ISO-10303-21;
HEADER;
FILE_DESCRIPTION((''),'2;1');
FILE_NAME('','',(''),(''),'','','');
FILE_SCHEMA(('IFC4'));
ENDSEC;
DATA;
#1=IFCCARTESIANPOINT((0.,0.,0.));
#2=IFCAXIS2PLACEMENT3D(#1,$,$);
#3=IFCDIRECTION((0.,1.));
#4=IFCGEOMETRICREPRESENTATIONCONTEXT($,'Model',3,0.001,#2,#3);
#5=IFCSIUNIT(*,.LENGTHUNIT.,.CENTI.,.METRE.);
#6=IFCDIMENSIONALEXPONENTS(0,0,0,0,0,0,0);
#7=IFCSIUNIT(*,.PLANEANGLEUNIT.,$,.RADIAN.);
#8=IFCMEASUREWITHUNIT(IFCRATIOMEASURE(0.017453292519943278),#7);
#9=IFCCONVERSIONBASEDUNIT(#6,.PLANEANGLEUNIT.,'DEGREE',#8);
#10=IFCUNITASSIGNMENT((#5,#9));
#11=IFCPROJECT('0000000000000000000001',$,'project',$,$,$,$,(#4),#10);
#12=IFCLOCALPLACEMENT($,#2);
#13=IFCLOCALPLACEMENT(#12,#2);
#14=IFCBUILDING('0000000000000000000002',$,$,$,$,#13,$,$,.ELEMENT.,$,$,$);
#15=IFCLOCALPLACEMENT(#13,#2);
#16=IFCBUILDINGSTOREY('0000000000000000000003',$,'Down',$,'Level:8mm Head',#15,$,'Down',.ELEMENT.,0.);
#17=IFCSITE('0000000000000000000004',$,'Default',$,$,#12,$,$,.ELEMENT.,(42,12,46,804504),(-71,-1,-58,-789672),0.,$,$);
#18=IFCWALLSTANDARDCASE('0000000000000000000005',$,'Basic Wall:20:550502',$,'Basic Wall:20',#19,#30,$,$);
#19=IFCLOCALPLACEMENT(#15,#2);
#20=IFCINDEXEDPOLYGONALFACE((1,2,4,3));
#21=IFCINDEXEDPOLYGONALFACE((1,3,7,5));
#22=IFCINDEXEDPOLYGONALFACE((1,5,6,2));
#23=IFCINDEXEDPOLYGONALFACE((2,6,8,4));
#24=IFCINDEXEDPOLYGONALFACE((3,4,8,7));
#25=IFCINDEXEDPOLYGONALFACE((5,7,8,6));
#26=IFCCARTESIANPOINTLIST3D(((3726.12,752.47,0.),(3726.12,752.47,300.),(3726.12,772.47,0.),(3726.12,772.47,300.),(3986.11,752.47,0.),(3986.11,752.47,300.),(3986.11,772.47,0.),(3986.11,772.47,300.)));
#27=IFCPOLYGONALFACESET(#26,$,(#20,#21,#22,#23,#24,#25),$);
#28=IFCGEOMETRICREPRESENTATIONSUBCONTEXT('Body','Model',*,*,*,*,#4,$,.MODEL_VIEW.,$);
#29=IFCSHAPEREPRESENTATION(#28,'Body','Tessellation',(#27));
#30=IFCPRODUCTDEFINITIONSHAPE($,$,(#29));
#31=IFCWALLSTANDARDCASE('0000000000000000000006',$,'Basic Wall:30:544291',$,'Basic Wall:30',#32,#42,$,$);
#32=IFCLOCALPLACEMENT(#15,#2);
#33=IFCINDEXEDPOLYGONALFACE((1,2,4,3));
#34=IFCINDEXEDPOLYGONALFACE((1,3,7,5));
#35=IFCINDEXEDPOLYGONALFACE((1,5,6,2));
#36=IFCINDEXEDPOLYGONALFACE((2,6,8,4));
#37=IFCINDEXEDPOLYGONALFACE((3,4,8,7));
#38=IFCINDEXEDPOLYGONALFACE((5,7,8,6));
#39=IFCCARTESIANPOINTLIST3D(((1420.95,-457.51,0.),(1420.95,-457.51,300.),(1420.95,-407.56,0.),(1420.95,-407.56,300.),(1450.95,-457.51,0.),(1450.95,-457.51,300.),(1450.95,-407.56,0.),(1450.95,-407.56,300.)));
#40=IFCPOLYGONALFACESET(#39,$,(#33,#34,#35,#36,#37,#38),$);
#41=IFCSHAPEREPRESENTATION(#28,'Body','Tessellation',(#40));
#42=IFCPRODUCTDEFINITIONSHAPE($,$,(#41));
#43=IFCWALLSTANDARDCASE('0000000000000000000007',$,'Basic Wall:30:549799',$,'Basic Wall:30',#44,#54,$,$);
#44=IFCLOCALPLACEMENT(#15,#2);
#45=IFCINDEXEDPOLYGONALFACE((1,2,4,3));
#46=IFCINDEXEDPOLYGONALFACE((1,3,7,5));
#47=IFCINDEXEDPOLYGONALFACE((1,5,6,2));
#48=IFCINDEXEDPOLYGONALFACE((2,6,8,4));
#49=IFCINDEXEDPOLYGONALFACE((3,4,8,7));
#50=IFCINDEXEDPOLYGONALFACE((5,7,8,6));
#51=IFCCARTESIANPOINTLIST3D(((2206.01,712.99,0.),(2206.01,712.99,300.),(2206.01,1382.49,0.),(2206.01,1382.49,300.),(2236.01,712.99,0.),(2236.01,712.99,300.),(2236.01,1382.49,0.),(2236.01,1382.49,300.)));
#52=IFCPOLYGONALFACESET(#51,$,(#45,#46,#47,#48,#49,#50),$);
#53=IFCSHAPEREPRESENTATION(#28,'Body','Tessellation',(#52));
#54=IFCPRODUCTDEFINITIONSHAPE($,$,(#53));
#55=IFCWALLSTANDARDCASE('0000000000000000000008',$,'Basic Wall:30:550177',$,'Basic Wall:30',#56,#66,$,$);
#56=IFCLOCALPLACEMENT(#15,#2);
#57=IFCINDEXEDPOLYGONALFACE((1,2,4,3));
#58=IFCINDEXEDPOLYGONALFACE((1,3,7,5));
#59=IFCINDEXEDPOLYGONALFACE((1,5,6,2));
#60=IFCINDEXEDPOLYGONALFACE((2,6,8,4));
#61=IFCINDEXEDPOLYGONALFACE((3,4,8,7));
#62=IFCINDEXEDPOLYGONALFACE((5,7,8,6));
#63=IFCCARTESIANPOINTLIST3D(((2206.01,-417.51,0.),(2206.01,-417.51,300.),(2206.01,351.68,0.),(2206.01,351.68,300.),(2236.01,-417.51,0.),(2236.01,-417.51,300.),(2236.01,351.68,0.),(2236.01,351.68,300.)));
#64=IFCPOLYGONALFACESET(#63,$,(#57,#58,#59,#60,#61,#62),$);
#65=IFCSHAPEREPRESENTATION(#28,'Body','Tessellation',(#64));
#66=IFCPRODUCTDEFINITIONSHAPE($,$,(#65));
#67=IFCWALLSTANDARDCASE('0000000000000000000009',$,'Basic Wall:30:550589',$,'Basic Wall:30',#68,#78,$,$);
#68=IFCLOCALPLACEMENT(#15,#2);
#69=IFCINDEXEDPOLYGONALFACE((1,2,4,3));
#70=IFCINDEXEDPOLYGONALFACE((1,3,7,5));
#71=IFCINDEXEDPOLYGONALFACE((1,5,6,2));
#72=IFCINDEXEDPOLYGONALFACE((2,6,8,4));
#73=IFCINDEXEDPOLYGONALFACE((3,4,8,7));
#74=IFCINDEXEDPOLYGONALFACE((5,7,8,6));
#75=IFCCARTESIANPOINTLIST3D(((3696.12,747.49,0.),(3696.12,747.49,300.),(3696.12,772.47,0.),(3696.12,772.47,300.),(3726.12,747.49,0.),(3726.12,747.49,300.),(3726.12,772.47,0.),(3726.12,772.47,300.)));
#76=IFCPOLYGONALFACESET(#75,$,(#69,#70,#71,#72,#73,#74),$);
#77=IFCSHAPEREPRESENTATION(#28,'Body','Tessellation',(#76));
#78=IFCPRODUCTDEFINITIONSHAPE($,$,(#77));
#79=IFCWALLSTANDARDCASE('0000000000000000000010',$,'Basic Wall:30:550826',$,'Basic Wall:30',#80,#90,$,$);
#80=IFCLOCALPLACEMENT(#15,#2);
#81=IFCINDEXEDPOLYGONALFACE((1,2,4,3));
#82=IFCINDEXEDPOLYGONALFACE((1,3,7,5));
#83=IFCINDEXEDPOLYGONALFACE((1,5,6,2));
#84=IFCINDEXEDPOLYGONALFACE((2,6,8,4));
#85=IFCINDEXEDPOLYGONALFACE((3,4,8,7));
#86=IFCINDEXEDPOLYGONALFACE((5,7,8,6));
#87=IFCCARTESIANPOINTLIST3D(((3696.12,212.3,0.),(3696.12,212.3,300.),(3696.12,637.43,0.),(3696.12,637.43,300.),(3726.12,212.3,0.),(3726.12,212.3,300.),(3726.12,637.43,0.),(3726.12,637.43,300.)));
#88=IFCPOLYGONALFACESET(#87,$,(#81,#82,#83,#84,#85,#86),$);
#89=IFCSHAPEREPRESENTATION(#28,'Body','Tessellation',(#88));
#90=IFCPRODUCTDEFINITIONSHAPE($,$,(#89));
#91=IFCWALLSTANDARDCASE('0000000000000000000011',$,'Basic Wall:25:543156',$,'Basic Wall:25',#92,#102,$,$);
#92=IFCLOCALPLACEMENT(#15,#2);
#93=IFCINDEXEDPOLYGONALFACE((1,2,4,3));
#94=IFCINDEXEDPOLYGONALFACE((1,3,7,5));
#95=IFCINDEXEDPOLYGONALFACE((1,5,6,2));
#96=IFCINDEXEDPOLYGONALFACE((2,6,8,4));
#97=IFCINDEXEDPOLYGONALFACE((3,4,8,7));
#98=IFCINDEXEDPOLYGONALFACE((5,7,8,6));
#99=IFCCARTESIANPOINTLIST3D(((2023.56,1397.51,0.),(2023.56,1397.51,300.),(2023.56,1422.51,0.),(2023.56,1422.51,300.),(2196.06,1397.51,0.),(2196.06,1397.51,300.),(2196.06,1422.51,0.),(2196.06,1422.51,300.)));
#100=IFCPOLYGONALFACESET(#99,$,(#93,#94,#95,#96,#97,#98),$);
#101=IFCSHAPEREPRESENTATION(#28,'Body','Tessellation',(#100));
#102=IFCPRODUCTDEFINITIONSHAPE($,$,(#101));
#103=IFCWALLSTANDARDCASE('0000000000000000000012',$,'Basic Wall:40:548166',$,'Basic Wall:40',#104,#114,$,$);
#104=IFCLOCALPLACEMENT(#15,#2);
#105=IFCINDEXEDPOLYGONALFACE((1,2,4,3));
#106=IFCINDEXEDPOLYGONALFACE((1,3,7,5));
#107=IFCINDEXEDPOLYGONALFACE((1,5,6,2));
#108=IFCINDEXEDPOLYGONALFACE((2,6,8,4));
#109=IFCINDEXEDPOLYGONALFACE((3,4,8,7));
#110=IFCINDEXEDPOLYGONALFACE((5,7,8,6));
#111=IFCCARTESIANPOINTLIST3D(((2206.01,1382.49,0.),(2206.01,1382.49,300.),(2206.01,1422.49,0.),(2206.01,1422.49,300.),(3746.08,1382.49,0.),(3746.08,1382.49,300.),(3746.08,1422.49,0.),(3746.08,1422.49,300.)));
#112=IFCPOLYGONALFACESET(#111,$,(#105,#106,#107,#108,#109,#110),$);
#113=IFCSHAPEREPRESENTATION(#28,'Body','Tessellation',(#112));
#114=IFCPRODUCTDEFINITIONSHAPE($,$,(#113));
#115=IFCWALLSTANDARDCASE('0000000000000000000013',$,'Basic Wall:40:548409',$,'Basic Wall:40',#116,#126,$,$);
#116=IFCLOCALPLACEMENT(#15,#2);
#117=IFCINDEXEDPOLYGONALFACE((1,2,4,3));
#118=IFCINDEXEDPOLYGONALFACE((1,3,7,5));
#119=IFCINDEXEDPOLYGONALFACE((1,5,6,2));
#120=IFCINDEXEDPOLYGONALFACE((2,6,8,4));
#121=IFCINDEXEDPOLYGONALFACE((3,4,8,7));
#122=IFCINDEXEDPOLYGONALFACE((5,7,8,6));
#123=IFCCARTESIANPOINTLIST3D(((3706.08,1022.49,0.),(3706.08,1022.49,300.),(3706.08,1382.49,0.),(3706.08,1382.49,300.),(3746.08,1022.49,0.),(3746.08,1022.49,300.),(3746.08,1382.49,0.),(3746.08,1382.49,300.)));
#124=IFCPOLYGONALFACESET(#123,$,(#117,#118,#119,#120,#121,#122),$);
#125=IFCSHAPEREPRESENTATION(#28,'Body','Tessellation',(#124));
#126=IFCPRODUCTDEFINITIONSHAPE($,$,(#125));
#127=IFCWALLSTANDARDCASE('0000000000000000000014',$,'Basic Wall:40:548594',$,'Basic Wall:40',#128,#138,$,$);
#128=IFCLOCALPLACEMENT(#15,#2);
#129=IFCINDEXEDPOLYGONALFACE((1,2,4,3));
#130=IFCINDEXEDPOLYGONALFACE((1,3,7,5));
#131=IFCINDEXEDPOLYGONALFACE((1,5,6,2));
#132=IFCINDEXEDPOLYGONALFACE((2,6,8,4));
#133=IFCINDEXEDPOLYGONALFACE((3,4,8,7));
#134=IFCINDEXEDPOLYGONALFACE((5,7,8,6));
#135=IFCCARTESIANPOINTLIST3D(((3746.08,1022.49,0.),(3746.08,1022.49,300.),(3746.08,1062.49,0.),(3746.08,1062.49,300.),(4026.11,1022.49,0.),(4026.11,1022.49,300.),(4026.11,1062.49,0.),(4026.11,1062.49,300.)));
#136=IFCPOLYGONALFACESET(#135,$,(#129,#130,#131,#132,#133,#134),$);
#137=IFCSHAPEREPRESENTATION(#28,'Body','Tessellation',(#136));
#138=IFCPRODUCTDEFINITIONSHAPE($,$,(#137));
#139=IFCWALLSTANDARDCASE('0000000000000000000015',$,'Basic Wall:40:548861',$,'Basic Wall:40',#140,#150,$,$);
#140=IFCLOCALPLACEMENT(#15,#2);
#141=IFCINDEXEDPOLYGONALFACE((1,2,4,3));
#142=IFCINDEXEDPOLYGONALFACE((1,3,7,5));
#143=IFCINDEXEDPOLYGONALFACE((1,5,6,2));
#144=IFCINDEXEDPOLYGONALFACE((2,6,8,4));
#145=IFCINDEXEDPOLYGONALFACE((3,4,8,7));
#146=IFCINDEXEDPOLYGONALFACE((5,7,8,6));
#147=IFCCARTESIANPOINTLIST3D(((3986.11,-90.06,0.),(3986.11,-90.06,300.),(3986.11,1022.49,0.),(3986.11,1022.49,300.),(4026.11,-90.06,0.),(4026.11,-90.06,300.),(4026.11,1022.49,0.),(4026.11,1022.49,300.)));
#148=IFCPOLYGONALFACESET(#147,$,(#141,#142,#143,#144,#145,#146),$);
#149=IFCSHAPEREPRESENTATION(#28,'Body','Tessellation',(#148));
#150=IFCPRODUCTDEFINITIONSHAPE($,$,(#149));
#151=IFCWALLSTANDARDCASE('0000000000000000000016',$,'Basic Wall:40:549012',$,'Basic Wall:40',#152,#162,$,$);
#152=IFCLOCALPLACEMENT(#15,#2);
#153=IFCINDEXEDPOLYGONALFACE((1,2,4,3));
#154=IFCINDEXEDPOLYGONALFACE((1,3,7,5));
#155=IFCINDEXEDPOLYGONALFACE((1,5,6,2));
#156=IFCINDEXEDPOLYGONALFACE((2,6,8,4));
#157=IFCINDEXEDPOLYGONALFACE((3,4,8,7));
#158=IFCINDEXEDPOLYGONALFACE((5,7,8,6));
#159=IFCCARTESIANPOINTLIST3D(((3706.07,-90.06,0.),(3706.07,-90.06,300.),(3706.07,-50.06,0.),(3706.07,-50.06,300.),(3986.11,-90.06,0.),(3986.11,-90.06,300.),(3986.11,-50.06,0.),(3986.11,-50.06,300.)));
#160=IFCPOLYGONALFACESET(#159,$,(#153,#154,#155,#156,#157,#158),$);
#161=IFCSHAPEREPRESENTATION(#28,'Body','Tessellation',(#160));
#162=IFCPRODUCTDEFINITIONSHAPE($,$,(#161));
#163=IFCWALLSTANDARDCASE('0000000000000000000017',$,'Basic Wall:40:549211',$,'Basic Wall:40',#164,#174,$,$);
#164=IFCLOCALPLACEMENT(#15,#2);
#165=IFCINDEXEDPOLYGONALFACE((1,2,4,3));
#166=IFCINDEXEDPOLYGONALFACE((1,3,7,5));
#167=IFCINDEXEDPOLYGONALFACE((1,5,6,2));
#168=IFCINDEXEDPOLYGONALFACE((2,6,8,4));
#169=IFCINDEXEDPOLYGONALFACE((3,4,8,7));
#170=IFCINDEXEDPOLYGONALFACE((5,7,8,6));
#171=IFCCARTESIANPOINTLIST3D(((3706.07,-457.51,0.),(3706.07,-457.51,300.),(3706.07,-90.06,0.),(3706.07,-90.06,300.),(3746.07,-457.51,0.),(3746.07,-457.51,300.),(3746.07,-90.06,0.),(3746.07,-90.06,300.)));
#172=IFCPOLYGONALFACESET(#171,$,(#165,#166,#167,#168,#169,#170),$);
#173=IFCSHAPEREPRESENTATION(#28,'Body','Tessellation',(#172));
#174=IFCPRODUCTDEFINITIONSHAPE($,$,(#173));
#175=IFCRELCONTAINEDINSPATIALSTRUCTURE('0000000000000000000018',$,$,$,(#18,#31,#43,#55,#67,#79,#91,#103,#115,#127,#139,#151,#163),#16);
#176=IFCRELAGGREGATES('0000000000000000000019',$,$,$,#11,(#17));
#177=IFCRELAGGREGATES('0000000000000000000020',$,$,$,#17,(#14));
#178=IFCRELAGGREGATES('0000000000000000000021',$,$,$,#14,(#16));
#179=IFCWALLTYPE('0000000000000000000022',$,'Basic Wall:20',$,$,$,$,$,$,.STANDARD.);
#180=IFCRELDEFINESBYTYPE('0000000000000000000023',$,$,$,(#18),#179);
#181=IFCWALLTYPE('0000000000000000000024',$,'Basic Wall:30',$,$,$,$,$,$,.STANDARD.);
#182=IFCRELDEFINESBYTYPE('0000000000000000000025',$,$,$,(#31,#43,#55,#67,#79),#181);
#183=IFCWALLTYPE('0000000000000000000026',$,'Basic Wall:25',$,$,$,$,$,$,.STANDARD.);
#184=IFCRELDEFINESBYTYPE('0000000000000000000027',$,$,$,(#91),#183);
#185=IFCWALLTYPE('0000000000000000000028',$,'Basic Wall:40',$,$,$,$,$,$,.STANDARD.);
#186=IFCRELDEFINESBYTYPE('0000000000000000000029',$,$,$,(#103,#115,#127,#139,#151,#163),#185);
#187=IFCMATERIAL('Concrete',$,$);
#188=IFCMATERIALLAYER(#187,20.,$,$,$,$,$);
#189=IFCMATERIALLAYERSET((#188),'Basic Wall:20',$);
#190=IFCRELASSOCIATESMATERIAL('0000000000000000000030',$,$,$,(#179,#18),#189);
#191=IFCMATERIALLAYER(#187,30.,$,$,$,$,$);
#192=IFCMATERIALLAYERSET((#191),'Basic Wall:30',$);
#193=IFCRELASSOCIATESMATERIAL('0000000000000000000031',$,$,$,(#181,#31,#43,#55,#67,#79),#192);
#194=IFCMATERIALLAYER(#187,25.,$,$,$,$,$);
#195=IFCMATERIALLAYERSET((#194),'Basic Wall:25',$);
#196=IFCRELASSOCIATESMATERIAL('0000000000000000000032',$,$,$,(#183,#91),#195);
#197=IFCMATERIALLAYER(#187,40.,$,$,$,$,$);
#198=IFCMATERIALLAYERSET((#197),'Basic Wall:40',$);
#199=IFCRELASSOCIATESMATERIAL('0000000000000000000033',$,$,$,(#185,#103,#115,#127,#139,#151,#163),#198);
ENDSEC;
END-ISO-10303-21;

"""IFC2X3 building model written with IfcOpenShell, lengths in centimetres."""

from ifc_helpers import new_model, entity, si_unit, converted_unit, direction, frame, frame_2d, origin, place, context, subcontext, project, spatial, rectangle, extrude, material, layer, layer_set, layer_usage, type_object, element, save


model = new_model("IFC2X3")

# Units and contexts
model_context = context("Model", 3, precision=0.001, world=origin(), true_north=direction((0.0, 1.0)))
body_context = subcontext(model_context, "Body", "Model", "MODEL_VIEW")
ifc_project = project(units=[si_unit("LENGTHUNIT", "METRE", prefix="CENTI"), converted_unit("PLANEANGLEUNIT", "DEGREE", entity("IfcRatioMeasure", 0.017453292519943278), si_unit("PLANEANGLEUNIT", "RADIAN"), dimensions=[0, 0, 0, 0, 0, 0, 0])], contexts=[model_context])

# Site, building, storey
site_placement = place(None, origin())
site = spatial("IfcSite", under=ifc_project, at=site_placement, Name="Default", CompositionType="ELEMENT", RefLatitude=(42, 12, 46, 804504), RefLongitude=(-71, -1, -58, -789672), RefElevation=0.0)
building_placement = place(site_placement, origin())
building = spatial("IfcBuilding", under=site, at=building_placement, CompositionType="ELEMENT")
storey_placement = place(building_placement, origin())
storey = spatial("IfcBuildingStorey", under=building, at=storey_placement, Name="Down", ObjectType="Level:8mm Head", LongName="Down", CompositionType="ELEMENT", Elevation=0.0)

# Shared definitions
ifc_material = material(Name="Concrete")

# Walls
ifc_layer_1 = layer(ifc_material, 20.0)
ifc_layer_set_1 = layer_set([ifc_layer_1], Name="Basic Wall:20")
wall_type_1 = type_object("IfcWallType", Name="Basic Wall:20", PredefinedType="STANDARD", material=ifc_layer_set_1)
ifc_layer_usage_1 = layer_usage(ifc_layer_set_1, "AXIS2", "POSITIVE", -10.0)
wall_1_placement = place(storey_placement, frame((3986.11, 762.47, 0.0), z_axis=(0.0, 0.0, 1.0), x_axis=(-1.0, 0.0, 0.0)))
element("IfcWallStandardCase", 1, at=wall_1_placement, inside=storey, type_object=wall_type_1, material=ifc_layer_usage_1, Name="Basic Wall:20:550502", ObjectType="Basic Wall:20", context=body_context, shape_type="SweptSolid", body=[
    extrude(rectangle(XDim=259.98, YDim=20.0, at=frame_2d((129.99, 0.0), x_axis=(-1.0, 0.0))), origin(), (0.0, 0.0, 1.0), 300.0),
])
ifc_layer_2 = layer(ifc_material, 30.0)
ifc_layer_set_2 = layer_set([ifc_layer_2], Name="Basic Wall:30")
ifc_layer_usage_2 = layer_usage(ifc_layer_set_2, "AXIS2", "NEGATIVE", 15.0)
wall_type_2 = type_object("IfcWallType", Name="Basic Wall:30", PredefinedType="STANDARD", material=ifc_layer_set_2)
wall_2_placement = place(storey_placement, frame((1435.95, -457.51, 0.0), z_axis=(0.0, 0.0, 1.0), x_axis=(0.0, 1.0, 0.0)))
element("IfcWallStandardCase", 2, at=wall_2_placement, inside=storey, type_object=wall_type_2, material=ifc_layer_usage_2, Name="Basic Wall:30:544291", ObjectType="Basic Wall:30", context=body_context, shape_type="SweptSolid", body=[
    extrude(rectangle(XDim=49.95, YDim=30.0, at=frame_2d((24.98, 0.0), x_axis=(-1.0, 0.0))), origin(), (0.0, 0.0, 1.0), 300.0),
])
ifc_layer_usage_3 = layer_usage(ifc_layer_set_2, "AXIS2", "POSITIVE", -15.0)
wall_3_placement = place(storey_placement, frame((2221.01, 1382.49, 0.0), z_axis=(0.0, 0.0, 1.0), x_axis=(0.0, -1.0, 0.0)))
element("IfcWallStandardCase", 3, at=wall_3_placement, inside=storey, type_object=wall_type_2, material=ifc_layer_usage_3, Name="Basic Wall:30:549799", ObjectType="Basic Wall:30", context=body_context, shape_type="SweptSolid", body=[
    extrude(rectangle(XDim=669.5, YDim=30.0, at=frame_2d((334.75, 0.0), x_axis=(-1.0, 0.0))), origin(), (0.0, 0.0, 1.0), 300.0),
])
ifc_layer_usage_4 = layer_usage(ifc_layer_set_2, "AXIS2", "POSITIVE", -15.0)
wall_4_placement = place(storey_placement, frame((2221.01, 351.68, 0.0), z_axis=(0.0, 0.0, 1.0), x_axis=(0.0, -1.0, 0.0)))
element("IfcWallStandardCase", 4, at=wall_4_placement, inside=storey, type_object=wall_type_2, material=ifc_layer_usage_4, Name="Basic Wall:30:550177", ObjectType="Basic Wall:30", context=body_context, shape_type="SweptSolid", body=[
    extrude(rectangle(XDim=769.19, YDim=30.0, at=frame_2d((384.6, 0.0), x_axis=(-1.0, 0.0))), origin(), (0.0, 0.0, 1.0), 300.0),
])
ifc_layer_usage_5 = layer_usage(ifc_layer_set_2, "AXIS2", "POSITIVE", -15.0)
wall_5_placement = place(storey_placement, frame((3711.12, 772.47, 0.0), z_axis=(0.0, 0.0, 1.0), x_axis=(0.0, -1.0, 0.0)))
element("IfcWallStandardCase", 5, at=wall_5_placement, inside=storey, type_object=wall_type_2, material=ifc_layer_usage_5, Name="Basic Wall:30:550589", ObjectType="Basic Wall:30", context=body_context, shape_type="SweptSolid", body=[
    extrude(rectangle(XDim=24.98, YDim=30.0, at=frame_2d((12.49, 0.0), x_axis=(-1.0, 0.0))), origin(), (0.0, 0.0, 1.0), 300.0),
])
ifc_layer_usage_6 = layer_usage(ifc_layer_set_2, "AXIS2", "POSITIVE", -15.0)
wall_6_placement = place(storey_placement, frame((3711.12, 637.43, 0.0), z_axis=(0.0, 0.0, 1.0), x_axis=(0.0, -1.0, 0.0)))
element("IfcWallStandardCase", 6, at=wall_6_placement, inside=storey, type_object=wall_type_2, material=ifc_layer_usage_6, Name="Basic Wall:30:550826", ObjectType="Basic Wall:30", context=body_context, shape_type="SweptSolid", body=[
    extrude(rectangle(XDim=425.13, YDim=30.0, at=frame_2d((212.56, 0.0), x_axis=(-1.0, 0.0))), origin(), (0.0, 0.0, 1.0), 300.0),
])
ifc_layer_3 = layer(ifc_material, 25.0)
ifc_layer_set_3 = layer_set([ifc_layer_3], Name="Basic Wall:25")
ifc_layer_usage_7 = layer_usage(ifc_layer_set_3, "AXIS2", "POSITIVE", -12.5)
wall_type_3 = type_object("IfcWallType", Name="Basic Wall:25", PredefinedType="STANDARD", material=ifc_layer_set_3)
wall_7_placement = place(storey_placement, frame((2023.56, 1410.01, 0.0)))
element("IfcWallStandardCase", 7, at=wall_7_placement, inside=storey, type_object=wall_type_3, material=ifc_layer_usage_7, Name="Basic Wall:25:543156", ObjectType="Basic Wall:25", context=body_context, shape_type="SweptSolid", body=[
    extrude(rectangle(XDim=172.51, YDim=25.0, at=frame_2d((86.25, 0.0), x_axis=(-1.0, 0.0))), origin(), (0.0, 0.0, 1.0), 300.0),
])
ifc_layer_4 = layer(ifc_material, 40.0)
ifc_layer_set_4 = layer_set([ifc_layer_4], Name="Basic Wall:40")
ifc_layer_usage_8 = layer_usage(ifc_layer_set_4, "AXIS2", "NEGATIVE", 20.0)
wall_type_4 = type_object("IfcWallType", Name="Basic Wall:40", PredefinedType="STANDARD", material=ifc_layer_set_4)
wall_8_placement = place(storey_placement, frame((2206.01, 1402.49, 0.0)))
element("IfcWallStandardCase", 8, at=wall_8_placement, inside=storey, type_object=wall_type_4, material=ifc_layer_usage_8, Name="Basic Wall:40:548166", ObjectType="Basic Wall:40", context=body_context, shape_type="SweptSolid", body=[
    extrude(rectangle(XDim=1540.07, YDim=40.0, at=frame_2d((770.03, 0.0), x_axis=(-1.0, 0.0))), origin(), (0.0, 0.0, 1.0), 300.0),
])
ifc_layer_usage_9 = layer_usage(ifc_layer_set_4, "AXIS2", "NEGATIVE", 20.0)
wall_9_placement = place(storey_placement, frame((3726.08, 1382.49, 0.0), z_axis=(0.0, 0.0, 1.0), x_axis=(0.0, -1.0, 0.0)))
element("IfcWallStandardCase", 9, at=wall_9_placement, inside=storey, type_object=wall_type_4, material=ifc_layer_usage_9, Name="Basic Wall:40:548409", ObjectType="Basic Wall:40", context=body_context, shape_type="SweptSolid", body=[
    extrude(rectangle(XDim=360.0, YDim=40.0, at=frame_2d((180.0, 0.0), x_axis=(-1.0, 0.0))), origin(), (0.0, 0.0, 1.0), 300.0),
])
ifc_layer_usage_10 = layer_usage(ifc_layer_set_4, "AXIS2", "POSITIVE", -20.0)
wall_10_placement = place(storey_placement, frame((3746.08, 1042.49, 0.0)))
element("IfcWallStandardCase", 10, at=wall_10_placement, inside=storey, type_object=wall_type_4, material=ifc_layer_usage_10, Name="Basic Wall:40:548594", ObjectType="Basic Wall:40", context=body_context, shape_type="SweptSolid", body=[
    extrude(rectangle(XDim=280.03, YDim=40.0, at=frame_2d((140.02, 0.0), x_axis=(-1.0, 0.0))), origin(), (0.0, 0.0, 1.0), 300.0),
])
ifc_layer_usage_11 = layer_usage(ifc_layer_set_4, "AXIS2", "NEGATIVE", 20.0)
wall_11_placement = place(storey_placement, frame((4006.11, 1022.49, 0.0), z_axis=(0.0, 0.0, 1.0), x_axis=(0.0, -1.0, 0.0)))
element("IfcWallStandardCase", 11, at=wall_11_placement, inside=storey, type_object=wall_type_4, material=ifc_layer_usage_11, Name="Basic Wall:40:548861", ObjectType="Basic Wall:40", context=body_context, shape_type="SweptSolid", body=[
    extrude(rectangle(XDim=1112.55, YDim=40.0, at=frame_2d((556.28, 0.0), x_axis=(-1.0, 0.0))), origin(), (0.0, 0.0, 1.0), 300.0),
])
ifc_layer_usage_12 = layer_usage(ifc_layer_set_4, "AXIS2", "NEGATIVE", 20.0)
wall_12_placement = place(storey_placement, frame((3986.11, -70.06, 0.0), z_axis=(0.0, 0.0, 1.0), x_axis=(-1.0, 0.0, 0.0)))
element("IfcWallStandardCase", 12, at=wall_12_placement, inside=storey, type_object=wall_type_4, material=ifc_layer_usage_12, Name="Basic Wall:40:549012", ObjectType="Basic Wall:40", context=body_context, shape_type="SweptSolid", body=[
    extrude(rectangle(XDim=280.04, YDim=40.0, at=frame_2d((140.02, 0.0), x_axis=(-1.0, 0.0))), origin(), (0.0, 0.0, 1.0), 300.0),
])
ifc_layer_usage_13 = layer_usage(ifc_layer_set_4, "AXIS2", "POSITIVE", -20.0)
wall_13_placement = place(storey_placement, frame((3726.07, -90.06, 0.0), z_axis=(0.0, 0.0, 1.0), x_axis=(0.0, -1.0, 0.0)))
element("IfcWallStandardCase", 13, at=wall_13_placement, inside=storey, type_object=wall_type_4, material=ifc_layer_usage_13, Name="Basic Wall:40:549211", ObjectType="Basic Wall:40", context=body_context, shape_type="SweptSolid", body=[
    extrude(rectangle(XDim=367.45, YDim=40.0, at=frame_2d((183.72, 0.0), x_axis=(-1.0, 0.0))), origin(), (0.0, 0.0, 1.0), 300.0),
])

save(model, "model.ifc")
